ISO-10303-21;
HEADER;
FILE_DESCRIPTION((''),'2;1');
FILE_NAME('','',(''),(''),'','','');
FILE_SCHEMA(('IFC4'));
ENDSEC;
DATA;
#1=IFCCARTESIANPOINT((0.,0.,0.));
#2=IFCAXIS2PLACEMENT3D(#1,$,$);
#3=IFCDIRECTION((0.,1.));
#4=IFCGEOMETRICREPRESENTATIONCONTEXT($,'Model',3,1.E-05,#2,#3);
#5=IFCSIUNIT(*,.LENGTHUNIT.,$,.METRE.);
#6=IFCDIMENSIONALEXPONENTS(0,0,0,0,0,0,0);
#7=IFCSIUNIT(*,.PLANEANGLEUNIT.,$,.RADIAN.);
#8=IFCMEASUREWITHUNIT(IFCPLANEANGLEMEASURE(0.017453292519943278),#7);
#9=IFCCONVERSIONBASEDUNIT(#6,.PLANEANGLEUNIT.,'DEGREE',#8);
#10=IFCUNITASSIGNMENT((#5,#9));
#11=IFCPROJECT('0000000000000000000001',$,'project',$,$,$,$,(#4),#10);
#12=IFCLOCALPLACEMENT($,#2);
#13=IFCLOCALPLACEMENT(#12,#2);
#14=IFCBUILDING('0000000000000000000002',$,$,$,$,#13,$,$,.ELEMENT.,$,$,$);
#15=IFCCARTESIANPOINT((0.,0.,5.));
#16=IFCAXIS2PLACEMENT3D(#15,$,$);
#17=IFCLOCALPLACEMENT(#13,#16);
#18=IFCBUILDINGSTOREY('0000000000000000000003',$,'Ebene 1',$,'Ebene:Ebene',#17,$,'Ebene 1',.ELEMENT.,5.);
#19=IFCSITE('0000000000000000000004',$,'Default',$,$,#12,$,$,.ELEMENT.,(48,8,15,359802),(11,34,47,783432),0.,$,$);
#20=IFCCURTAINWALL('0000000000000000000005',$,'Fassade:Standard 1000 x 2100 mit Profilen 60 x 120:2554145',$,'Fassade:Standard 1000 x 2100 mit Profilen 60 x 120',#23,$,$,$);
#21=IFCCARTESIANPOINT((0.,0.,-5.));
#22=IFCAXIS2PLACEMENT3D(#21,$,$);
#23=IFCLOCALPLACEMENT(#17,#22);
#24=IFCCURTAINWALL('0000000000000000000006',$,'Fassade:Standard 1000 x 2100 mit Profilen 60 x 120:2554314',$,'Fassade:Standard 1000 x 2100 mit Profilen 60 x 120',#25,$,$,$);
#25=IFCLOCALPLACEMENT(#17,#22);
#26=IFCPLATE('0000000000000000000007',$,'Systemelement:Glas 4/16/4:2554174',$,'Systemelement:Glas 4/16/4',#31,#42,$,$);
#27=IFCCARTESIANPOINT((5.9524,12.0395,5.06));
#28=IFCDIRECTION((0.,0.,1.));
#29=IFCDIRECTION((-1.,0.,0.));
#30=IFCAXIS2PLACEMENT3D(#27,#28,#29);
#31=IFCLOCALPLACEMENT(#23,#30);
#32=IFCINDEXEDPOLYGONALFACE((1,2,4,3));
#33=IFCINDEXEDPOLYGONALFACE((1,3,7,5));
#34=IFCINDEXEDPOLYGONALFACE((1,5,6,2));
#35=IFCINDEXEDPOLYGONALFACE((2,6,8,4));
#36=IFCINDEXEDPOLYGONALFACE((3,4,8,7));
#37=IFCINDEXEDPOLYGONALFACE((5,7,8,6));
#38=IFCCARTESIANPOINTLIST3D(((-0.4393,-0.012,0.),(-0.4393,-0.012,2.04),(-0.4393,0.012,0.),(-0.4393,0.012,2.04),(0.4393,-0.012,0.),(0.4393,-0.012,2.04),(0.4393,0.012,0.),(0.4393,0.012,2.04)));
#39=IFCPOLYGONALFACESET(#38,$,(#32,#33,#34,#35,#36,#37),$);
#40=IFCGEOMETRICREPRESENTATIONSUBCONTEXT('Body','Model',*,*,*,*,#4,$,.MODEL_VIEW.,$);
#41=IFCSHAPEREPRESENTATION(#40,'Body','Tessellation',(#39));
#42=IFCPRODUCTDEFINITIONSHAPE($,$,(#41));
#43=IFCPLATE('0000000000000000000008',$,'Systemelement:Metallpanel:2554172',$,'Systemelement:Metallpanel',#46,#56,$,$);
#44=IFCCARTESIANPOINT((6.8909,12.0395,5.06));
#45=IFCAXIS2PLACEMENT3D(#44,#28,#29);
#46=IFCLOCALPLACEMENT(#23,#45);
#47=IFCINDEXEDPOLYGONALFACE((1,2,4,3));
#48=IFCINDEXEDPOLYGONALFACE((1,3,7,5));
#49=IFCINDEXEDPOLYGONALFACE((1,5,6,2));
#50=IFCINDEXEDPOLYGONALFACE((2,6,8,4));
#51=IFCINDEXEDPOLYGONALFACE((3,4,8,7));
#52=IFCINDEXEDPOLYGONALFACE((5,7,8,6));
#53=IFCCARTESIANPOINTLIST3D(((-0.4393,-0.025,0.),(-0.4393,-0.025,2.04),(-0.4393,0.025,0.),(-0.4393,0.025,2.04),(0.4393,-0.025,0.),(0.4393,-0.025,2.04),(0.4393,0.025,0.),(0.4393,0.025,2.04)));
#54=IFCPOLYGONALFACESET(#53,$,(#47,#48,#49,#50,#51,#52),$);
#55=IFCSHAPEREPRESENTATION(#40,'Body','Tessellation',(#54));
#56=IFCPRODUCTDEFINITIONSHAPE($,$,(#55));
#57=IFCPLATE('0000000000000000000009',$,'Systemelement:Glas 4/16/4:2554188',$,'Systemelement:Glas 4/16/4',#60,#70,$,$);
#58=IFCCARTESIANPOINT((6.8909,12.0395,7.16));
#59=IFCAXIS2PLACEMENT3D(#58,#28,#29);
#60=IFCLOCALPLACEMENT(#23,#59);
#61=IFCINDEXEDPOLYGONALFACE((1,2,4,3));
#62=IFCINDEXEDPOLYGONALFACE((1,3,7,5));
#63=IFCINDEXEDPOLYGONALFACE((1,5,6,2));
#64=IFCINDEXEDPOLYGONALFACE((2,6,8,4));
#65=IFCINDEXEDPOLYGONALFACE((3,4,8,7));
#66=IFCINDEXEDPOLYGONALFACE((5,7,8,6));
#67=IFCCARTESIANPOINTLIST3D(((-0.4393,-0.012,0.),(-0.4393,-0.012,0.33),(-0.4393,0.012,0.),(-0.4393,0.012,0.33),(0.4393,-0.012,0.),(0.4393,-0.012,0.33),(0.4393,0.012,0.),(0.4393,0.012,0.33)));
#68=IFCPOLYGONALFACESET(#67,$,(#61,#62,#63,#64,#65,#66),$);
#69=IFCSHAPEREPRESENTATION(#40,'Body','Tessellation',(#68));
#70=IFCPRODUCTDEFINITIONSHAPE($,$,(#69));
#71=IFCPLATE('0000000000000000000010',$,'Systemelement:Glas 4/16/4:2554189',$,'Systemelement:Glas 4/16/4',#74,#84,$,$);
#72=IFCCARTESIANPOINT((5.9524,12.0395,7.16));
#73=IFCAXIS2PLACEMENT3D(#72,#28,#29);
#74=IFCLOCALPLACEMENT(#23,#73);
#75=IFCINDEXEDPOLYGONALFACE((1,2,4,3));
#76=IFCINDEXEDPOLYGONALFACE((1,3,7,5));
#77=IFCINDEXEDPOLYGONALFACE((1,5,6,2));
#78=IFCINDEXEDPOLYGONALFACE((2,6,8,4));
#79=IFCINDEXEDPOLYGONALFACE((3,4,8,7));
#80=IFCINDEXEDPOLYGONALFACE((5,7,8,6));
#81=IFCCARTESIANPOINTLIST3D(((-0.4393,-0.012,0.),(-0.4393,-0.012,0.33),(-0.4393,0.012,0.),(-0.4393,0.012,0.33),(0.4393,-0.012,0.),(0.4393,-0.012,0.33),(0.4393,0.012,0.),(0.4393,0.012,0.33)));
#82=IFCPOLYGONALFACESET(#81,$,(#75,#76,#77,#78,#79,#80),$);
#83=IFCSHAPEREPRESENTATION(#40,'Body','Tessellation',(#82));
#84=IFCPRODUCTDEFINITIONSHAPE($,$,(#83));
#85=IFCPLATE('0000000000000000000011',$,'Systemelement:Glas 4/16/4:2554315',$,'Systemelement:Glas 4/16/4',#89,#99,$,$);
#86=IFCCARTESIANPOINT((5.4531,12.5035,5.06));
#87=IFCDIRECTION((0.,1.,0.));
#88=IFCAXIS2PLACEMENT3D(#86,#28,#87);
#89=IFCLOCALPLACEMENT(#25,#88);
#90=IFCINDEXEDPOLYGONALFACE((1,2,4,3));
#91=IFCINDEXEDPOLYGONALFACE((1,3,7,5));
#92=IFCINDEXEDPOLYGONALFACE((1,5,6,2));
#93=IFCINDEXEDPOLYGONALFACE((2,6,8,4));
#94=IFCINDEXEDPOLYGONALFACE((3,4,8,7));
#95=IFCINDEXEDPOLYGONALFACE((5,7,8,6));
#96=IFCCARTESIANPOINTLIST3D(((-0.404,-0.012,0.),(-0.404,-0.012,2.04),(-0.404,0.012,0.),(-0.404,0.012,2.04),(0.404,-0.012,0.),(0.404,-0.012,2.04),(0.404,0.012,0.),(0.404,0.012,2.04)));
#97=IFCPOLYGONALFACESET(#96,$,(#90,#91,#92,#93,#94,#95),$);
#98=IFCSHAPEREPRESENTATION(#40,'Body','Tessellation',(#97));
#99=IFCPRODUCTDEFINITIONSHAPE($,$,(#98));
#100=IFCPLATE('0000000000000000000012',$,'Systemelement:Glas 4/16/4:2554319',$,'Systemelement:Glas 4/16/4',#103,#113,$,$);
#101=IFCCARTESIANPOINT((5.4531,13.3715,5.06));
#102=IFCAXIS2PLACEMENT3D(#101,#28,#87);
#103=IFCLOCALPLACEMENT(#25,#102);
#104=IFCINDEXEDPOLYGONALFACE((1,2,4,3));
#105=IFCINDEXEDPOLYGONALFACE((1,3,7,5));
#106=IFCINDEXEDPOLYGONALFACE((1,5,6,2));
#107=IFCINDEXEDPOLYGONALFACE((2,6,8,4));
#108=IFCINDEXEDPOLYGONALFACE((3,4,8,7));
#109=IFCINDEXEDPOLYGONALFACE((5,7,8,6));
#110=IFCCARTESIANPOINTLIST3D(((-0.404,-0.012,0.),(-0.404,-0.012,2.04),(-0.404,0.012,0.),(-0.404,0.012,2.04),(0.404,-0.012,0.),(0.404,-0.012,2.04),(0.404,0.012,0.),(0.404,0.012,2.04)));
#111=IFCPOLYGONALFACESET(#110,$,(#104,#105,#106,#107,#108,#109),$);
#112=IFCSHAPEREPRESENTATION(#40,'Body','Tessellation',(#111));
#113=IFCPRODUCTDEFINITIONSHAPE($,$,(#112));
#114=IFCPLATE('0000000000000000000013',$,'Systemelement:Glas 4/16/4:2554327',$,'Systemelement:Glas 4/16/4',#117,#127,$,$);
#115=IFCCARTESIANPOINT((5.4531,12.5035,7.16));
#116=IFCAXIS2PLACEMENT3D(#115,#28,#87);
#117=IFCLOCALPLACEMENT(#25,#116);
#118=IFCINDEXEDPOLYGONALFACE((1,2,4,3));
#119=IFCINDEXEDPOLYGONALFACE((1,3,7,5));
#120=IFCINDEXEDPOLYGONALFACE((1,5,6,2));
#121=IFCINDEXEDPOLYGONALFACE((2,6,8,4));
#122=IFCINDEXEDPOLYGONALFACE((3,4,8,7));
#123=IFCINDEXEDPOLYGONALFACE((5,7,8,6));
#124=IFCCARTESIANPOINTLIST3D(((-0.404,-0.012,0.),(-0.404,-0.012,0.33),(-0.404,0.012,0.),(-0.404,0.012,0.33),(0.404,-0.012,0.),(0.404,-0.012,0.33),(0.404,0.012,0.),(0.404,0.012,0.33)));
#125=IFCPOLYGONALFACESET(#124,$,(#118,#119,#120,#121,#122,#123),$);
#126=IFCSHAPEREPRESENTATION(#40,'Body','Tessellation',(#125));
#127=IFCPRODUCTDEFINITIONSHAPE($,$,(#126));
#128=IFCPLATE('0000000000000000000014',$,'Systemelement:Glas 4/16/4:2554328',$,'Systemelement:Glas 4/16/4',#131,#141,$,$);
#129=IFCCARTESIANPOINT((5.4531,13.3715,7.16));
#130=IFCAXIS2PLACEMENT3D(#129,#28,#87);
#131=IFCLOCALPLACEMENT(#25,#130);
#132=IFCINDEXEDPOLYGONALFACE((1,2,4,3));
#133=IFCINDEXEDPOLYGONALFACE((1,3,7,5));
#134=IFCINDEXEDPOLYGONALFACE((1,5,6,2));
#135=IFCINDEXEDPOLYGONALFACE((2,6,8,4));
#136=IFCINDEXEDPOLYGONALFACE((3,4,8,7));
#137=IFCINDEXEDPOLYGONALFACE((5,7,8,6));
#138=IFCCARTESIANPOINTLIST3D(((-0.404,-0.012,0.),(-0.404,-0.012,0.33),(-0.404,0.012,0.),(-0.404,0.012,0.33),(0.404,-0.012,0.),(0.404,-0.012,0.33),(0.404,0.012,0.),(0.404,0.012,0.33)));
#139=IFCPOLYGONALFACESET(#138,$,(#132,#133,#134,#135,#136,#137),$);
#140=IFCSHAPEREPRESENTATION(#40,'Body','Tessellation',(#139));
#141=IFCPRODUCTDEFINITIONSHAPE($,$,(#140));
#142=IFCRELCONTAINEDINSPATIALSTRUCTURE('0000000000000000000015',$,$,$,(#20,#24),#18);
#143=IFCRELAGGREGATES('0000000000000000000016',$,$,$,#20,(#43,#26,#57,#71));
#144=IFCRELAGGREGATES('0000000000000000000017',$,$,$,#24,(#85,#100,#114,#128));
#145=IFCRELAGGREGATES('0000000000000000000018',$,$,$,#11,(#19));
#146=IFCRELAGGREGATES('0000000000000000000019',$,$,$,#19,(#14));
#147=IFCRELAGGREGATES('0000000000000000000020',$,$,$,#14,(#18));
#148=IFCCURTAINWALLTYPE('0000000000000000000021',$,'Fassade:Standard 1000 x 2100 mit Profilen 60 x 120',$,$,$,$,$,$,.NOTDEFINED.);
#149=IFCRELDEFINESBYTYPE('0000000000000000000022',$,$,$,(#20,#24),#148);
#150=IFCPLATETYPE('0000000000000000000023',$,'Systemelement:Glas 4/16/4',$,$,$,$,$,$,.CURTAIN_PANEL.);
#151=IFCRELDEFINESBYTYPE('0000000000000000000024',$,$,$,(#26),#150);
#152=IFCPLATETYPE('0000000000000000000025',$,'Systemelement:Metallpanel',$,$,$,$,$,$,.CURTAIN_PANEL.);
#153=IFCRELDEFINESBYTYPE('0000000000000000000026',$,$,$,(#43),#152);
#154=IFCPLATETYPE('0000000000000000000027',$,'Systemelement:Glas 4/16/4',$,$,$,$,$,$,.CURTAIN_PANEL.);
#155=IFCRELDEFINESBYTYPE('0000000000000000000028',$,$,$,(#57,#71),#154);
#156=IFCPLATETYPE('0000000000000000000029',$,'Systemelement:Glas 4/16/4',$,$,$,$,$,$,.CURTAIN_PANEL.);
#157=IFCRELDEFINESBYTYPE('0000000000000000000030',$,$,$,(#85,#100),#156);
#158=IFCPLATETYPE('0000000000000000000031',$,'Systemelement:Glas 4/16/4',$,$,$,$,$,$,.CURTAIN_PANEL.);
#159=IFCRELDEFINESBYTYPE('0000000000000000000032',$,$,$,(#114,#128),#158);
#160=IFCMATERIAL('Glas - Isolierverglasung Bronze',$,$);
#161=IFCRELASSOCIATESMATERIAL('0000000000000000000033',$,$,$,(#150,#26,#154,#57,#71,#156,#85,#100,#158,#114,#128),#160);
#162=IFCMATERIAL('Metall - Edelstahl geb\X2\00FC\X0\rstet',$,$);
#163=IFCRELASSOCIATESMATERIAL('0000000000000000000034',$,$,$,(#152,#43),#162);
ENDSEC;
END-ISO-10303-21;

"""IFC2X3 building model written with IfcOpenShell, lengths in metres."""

from ifc_helpers import new_model, entity, si_unit, converted_unit, direction, frame, origin, origin_2d_with_axis, place, context, subcontext, project, spatial, rectangle, extrude, source, transform, mapped, material, type_object, type_shapes, element, aggregate, save


model = new_model("IFC2X3")

# Units and contexts
model_context = context("Model", 3, precision=1e-05, world=origin(), true_north=direction((0.0, 1.0)))
body_context = subcontext(model_context, "Body", "Model", "MODEL_VIEW")
ifc_project = project(units=[si_unit("LENGTHUNIT", "METRE"), converted_unit("PLANEANGLEUNIT", "DEGREE", entity("IfcPlaneAngleMeasure", 0.017453292519943278), si_unit("PLANEANGLEUNIT", "RADIAN"), dimensions=[0, 0, 0, 0, 0, 0, 0])], contexts=[model_context])

# Site, building, storey
site_placement = place(None, origin())
site = spatial("IfcSite", under=ifc_project, at=site_placement, Name="Default", CompositionType="ELEMENT", RefLatitude=(48, 8, 15, 359802), RefLongitude=(11, 34, 47, 783432), RefElevation=0.0)
building_placement = place(site_placement, origin())
building = spatial("IfcBuilding", under=site, at=building_placement, CompositionType="ELEMENT")
storey_placement = place(building_placement, frame((0.0, 0.0, 5.0)))
storey = spatial("IfcBuildingStorey", under=building, at=storey_placement, Name="Ebene 1", ObjectType="Ebene:Ebene", LongName="Ebene 1", CompositionType="ELEMENT", Elevation=5.0)

# Curtain walls
curtain_wall_type = type_object("IfcCurtainWallType", Name="Fassade:Standard 1000 x 2100 mit Profilen 60 x 120", PredefinedType="NOTDEFINED")
curtain_wall_1_placement = place(storey_placement, frame((0.0, 0.0, -5.0)))
curtain_wall_1 = element("IfcCurtainWall", 1, at=curtain_wall_1_placement, inside=storey, type_object=curtain_wall_type, Name="Fassade:Standard 1000 x 2100 mit Profilen 60 x 120:2554145", ObjectType="Fassade:Standard 1000 x 2100 mit Profilen 60 x 120")
curtain_wall_2_placement = place(storey_placement, frame((0.0, 0.0, -5.0)))
curtain_wall_2 = element("IfcCurtainWall", 2, at=curtain_wall_2_placement, inside=storey, type_object=curtain_wall_type, Name="Fassade:Standard 1000 x 2100 mit Profilen 60 x 120:2554314", ObjectType="Fassade:Standard 1000 x 2100 mit Profilen 60 x 120")

# Plates
ifc_material_1 = material(Name="Glas - Isolierverglasung Bronze")
plate_type_1 = type_object("IfcPlateType", Name="Systemelement:Glas 4/16/4", PredefinedType="CURTAIN_PANEL", material=ifc_material_1)
shared_shape_1 = source(origin(), body_context, "Body", "SweptSolid", [
    extrude(rectangle(XDim=0.024, YDim=0.8786, at=origin_2d_with_axis()), frame((0.0, 0.0, 0.0), z_axis=(0.0, 0.0, 1.0), x_axis=(0.0, 1.0, 0.0)), (0.0, 0.0, 1.0), 2.04),
])
type_shapes(plate_type_1, [shared_shape_1])
plate_1_placement = place(curtain_wall_1_placement, frame((5.9524, 12.0395, 5.06), z_axis=(0.0, 0.0, 1.0), x_axis=(-1.0, 0.0, 0.0)))
plate_1 = element("IfcPlate", 3, at=plate_1_placement, type_object=plate_type_1, material=ifc_material_1, Name="Systemelement:Glas 4/16/4:2554174", ObjectType="Systemelement:Glas 4/16/4", context=body_context, shape_type="MappedRepresentation", body=[
    mapped(shared_shape_1, transform((0.0, 0.0, 0.0), scale=1.0)),
])
ifc_material_2 = material(Name="Metall - Edelstahl gebürstet")
plate_type_2 = type_object("IfcPlateType", Name="Systemelement:Metallpanel", PredefinedType="CURTAIN_PANEL", material=ifc_material_2)
shared_shape_2 = source(origin(), body_context, "Body", "SweptSolid", [
    extrude(rectangle(XDim=0.05, YDim=0.8786, at=origin_2d_with_axis()), frame((0.0, 0.0, 0.0), z_axis=(0.0, 0.0, 1.0), x_axis=(0.0, 1.0, 0.0)), (0.0, 0.0, 1.0), 2.04),
])
type_shapes(plate_type_2, [shared_shape_2])
plate_2_placement = place(curtain_wall_1_placement, frame((6.8909, 12.0395, 5.06), z_axis=(0.0, 0.0, 1.0), x_axis=(-1.0, 0.0, 0.0)))
plate_2 = element("IfcPlate", 4, at=plate_2_placement, type_object=plate_type_2, material=ifc_material_2, Name="Systemelement:Metallpanel:2554172", ObjectType="Systemelement:Metallpanel", context=body_context, shape_type="MappedRepresentation", body=[
    mapped(shared_shape_2, transform((0.0, 0.0, 0.0), scale=1.0)),
])
plate_type_3 = type_object("IfcPlateType", Name="Systemelement:Glas 4/16/4", PredefinedType="CURTAIN_PANEL", material=ifc_material_1)
shared_shape_3 = source(origin(), body_context, "Body", "SweptSolid", [
    extrude(rectangle(XDim=0.024, YDim=0.8786, at=origin_2d_with_axis()), frame((0.0, 0.0, 0.0), z_axis=(0.0, 0.0, 1.0), x_axis=(0.0, 1.0, 0.0)), (0.0, 0.0, 1.0), 0.33),
])
type_shapes(plate_type_3, [shared_shape_3])
plate_3_placement = place(curtain_wall_1_placement, frame((6.8909, 12.0395, 7.16), z_axis=(0.0, 0.0, 1.0), x_axis=(-1.0, 0.0, 0.0)))
plate_3 = element("IfcPlate", 5, at=plate_3_placement, type_object=plate_type_3, material=ifc_material_1, Name="Systemelement:Glas 4/16/4:2554188", ObjectType="Systemelement:Glas 4/16/4", context=body_context, shape_type="MappedRepresentation", body=[
    mapped(shared_shape_3, transform((0.0, 0.0, 0.0), scale=1.0)),
])
plate_4_placement = place(curtain_wall_1_placement, frame((5.9524, 12.0395, 7.16), z_axis=(0.0, 0.0, 1.0), x_axis=(-1.0, 0.0, 0.0)))
plate_4 = element("IfcPlate", 6, at=plate_4_placement, type_object=plate_type_3, material=ifc_material_1, Name="Systemelement:Glas 4/16/4:2554189", ObjectType="Systemelement:Glas 4/16/4", context=body_context, shape_type="MappedRepresentation", body=[
    mapped(shared_shape_3, transform((0.0, 0.0, 0.0), scale=1.0)),
])
aggregate(curtain_wall_1, [plate_2, plate_1, plate_3, plate_4])
plate_type_4 = type_object("IfcPlateType", Name="Systemelement:Glas 4/16/4", PredefinedType="CURTAIN_PANEL", material=ifc_material_1)
shared_shape_4 = source(origin(), body_context, "Body", "SweptSolid", [
    extrude(rectangle(XDim=0.024, YDim=0.808, at=origin_2d_with_axis()), frame((0.0, 0.0, 0.0), z_axis=(0.0, 0.0, 1.0), x_axis=(0.0, 1.0, 0.0)), (0.0, 0.0, 1.0), 2.04),
])
type_shapes(plate_type_4, [shared_shape_4])
plate_5_placement = place(curtain_wall_2_placement, frame((5.4531, 12.5035, 5.06), z_axis=(0.0, 0.0, 1.0), x_axis=(0.0, 1.0, 0.0)))
plate_5 = element("IfcPlate", 7, at=plate_5_placement, type_object=plate_type_4, material=ifc_material_1, Name="Systemelement:Glas 4/16/4:2554315", ObjectType="Systemelement:Glas 4/16/4", context=body_context, shape_type="MappedRepresentation", body=[
    mapped(shared_shape_4, transform((0.0, 0.0, 0.0), scale=1.0)),
])
plate_6_placement = place(curtain_wall_2_placement, frame((5.4531, 13.3715, 5.06), z_axis=(0.0, 0.0, 1.0), x_axis=(0.0, 1.0, 0.0)))
plate_6 = element("IfcPlate", 8, at=plate_6_placement, type_object=plate_type_4, material=ifc_material_1, Name="Systemelement:Glas 4/16/4:2554319", ObjectType="Systemelement:Glas 4/16/4", context=body_context, shape_type="MappedRepresentation", body=[
    mapped(shared_shape_4, transform((0.0, 0.0, 0.0), scale=1.0)),
])
plate_type_5 = type_object("IfcPlateType", Name="Systemelement:Glas 4/16/4", PredefinedType="CURTAIN_PANEL", material=ifc_material_1)
shared_shape_5 = source(origin(), body_context, "Body", "SweptSolid", [
    extrude(rectangle(XDim=0.024, YDim=0.808, at=origin_2d_with_axis()), frame((0.0, 0.0, 0.0), z_axis=(0.0, 0.0, 1.0), x_axis=(0.0, 1.0, 0.0)), (0.0, 0.0, 1.0), 0.33),
])
type_shapes(plate_type_5, [shared_shape_5])
plate_7_placement = place(curtain_wall_2_placement, frame((5.4531, 12.5035, 7.16), z_axis=(0.0, 0.0, 1.0), x_axis=(0.0, 1.0, 0.0)))
plate_7 = element("IfcPlate", 9, at=plate_7_placement, type_object=plate_type_5, material=ifc_material_1, Name="Systemelement:Glas 4/16/4:2554327", ObjectType="Systemelement:Glas 4/16/4", context=body_context, shape_type="MappedRepresentation", body=[
    mapped(shared_shape_5, transform((0.0, 0.0, 0.0), scale=1.0)),
])
plate_8_placement = place(curtain_wall_2_placement, frame((5.4531, 13.3715, 7.16), z_axis=(0.0, 0.0, 1.0), x_axis=(0.0, 1.0, 0.0)))
plate_8 = element("IfcPlate", 10, at=plate_8_placement, type_object=plate_type_5, material=ifc_material_1, Name="Systemelement:Glas 4/16/4:2554328", ObjectType="Systemelement:Glas 4/16/4", context=body_context, shape_type="MappedRepresentation", body=[
    mapped(shared_shape_5, transform((0.0, 0.0, 0.0), scale=1.0)),
])
aggregate(curtain_wall_2, [plate_5, plate_6, plate_7, plate_8])

save(model, "model.ifc")
